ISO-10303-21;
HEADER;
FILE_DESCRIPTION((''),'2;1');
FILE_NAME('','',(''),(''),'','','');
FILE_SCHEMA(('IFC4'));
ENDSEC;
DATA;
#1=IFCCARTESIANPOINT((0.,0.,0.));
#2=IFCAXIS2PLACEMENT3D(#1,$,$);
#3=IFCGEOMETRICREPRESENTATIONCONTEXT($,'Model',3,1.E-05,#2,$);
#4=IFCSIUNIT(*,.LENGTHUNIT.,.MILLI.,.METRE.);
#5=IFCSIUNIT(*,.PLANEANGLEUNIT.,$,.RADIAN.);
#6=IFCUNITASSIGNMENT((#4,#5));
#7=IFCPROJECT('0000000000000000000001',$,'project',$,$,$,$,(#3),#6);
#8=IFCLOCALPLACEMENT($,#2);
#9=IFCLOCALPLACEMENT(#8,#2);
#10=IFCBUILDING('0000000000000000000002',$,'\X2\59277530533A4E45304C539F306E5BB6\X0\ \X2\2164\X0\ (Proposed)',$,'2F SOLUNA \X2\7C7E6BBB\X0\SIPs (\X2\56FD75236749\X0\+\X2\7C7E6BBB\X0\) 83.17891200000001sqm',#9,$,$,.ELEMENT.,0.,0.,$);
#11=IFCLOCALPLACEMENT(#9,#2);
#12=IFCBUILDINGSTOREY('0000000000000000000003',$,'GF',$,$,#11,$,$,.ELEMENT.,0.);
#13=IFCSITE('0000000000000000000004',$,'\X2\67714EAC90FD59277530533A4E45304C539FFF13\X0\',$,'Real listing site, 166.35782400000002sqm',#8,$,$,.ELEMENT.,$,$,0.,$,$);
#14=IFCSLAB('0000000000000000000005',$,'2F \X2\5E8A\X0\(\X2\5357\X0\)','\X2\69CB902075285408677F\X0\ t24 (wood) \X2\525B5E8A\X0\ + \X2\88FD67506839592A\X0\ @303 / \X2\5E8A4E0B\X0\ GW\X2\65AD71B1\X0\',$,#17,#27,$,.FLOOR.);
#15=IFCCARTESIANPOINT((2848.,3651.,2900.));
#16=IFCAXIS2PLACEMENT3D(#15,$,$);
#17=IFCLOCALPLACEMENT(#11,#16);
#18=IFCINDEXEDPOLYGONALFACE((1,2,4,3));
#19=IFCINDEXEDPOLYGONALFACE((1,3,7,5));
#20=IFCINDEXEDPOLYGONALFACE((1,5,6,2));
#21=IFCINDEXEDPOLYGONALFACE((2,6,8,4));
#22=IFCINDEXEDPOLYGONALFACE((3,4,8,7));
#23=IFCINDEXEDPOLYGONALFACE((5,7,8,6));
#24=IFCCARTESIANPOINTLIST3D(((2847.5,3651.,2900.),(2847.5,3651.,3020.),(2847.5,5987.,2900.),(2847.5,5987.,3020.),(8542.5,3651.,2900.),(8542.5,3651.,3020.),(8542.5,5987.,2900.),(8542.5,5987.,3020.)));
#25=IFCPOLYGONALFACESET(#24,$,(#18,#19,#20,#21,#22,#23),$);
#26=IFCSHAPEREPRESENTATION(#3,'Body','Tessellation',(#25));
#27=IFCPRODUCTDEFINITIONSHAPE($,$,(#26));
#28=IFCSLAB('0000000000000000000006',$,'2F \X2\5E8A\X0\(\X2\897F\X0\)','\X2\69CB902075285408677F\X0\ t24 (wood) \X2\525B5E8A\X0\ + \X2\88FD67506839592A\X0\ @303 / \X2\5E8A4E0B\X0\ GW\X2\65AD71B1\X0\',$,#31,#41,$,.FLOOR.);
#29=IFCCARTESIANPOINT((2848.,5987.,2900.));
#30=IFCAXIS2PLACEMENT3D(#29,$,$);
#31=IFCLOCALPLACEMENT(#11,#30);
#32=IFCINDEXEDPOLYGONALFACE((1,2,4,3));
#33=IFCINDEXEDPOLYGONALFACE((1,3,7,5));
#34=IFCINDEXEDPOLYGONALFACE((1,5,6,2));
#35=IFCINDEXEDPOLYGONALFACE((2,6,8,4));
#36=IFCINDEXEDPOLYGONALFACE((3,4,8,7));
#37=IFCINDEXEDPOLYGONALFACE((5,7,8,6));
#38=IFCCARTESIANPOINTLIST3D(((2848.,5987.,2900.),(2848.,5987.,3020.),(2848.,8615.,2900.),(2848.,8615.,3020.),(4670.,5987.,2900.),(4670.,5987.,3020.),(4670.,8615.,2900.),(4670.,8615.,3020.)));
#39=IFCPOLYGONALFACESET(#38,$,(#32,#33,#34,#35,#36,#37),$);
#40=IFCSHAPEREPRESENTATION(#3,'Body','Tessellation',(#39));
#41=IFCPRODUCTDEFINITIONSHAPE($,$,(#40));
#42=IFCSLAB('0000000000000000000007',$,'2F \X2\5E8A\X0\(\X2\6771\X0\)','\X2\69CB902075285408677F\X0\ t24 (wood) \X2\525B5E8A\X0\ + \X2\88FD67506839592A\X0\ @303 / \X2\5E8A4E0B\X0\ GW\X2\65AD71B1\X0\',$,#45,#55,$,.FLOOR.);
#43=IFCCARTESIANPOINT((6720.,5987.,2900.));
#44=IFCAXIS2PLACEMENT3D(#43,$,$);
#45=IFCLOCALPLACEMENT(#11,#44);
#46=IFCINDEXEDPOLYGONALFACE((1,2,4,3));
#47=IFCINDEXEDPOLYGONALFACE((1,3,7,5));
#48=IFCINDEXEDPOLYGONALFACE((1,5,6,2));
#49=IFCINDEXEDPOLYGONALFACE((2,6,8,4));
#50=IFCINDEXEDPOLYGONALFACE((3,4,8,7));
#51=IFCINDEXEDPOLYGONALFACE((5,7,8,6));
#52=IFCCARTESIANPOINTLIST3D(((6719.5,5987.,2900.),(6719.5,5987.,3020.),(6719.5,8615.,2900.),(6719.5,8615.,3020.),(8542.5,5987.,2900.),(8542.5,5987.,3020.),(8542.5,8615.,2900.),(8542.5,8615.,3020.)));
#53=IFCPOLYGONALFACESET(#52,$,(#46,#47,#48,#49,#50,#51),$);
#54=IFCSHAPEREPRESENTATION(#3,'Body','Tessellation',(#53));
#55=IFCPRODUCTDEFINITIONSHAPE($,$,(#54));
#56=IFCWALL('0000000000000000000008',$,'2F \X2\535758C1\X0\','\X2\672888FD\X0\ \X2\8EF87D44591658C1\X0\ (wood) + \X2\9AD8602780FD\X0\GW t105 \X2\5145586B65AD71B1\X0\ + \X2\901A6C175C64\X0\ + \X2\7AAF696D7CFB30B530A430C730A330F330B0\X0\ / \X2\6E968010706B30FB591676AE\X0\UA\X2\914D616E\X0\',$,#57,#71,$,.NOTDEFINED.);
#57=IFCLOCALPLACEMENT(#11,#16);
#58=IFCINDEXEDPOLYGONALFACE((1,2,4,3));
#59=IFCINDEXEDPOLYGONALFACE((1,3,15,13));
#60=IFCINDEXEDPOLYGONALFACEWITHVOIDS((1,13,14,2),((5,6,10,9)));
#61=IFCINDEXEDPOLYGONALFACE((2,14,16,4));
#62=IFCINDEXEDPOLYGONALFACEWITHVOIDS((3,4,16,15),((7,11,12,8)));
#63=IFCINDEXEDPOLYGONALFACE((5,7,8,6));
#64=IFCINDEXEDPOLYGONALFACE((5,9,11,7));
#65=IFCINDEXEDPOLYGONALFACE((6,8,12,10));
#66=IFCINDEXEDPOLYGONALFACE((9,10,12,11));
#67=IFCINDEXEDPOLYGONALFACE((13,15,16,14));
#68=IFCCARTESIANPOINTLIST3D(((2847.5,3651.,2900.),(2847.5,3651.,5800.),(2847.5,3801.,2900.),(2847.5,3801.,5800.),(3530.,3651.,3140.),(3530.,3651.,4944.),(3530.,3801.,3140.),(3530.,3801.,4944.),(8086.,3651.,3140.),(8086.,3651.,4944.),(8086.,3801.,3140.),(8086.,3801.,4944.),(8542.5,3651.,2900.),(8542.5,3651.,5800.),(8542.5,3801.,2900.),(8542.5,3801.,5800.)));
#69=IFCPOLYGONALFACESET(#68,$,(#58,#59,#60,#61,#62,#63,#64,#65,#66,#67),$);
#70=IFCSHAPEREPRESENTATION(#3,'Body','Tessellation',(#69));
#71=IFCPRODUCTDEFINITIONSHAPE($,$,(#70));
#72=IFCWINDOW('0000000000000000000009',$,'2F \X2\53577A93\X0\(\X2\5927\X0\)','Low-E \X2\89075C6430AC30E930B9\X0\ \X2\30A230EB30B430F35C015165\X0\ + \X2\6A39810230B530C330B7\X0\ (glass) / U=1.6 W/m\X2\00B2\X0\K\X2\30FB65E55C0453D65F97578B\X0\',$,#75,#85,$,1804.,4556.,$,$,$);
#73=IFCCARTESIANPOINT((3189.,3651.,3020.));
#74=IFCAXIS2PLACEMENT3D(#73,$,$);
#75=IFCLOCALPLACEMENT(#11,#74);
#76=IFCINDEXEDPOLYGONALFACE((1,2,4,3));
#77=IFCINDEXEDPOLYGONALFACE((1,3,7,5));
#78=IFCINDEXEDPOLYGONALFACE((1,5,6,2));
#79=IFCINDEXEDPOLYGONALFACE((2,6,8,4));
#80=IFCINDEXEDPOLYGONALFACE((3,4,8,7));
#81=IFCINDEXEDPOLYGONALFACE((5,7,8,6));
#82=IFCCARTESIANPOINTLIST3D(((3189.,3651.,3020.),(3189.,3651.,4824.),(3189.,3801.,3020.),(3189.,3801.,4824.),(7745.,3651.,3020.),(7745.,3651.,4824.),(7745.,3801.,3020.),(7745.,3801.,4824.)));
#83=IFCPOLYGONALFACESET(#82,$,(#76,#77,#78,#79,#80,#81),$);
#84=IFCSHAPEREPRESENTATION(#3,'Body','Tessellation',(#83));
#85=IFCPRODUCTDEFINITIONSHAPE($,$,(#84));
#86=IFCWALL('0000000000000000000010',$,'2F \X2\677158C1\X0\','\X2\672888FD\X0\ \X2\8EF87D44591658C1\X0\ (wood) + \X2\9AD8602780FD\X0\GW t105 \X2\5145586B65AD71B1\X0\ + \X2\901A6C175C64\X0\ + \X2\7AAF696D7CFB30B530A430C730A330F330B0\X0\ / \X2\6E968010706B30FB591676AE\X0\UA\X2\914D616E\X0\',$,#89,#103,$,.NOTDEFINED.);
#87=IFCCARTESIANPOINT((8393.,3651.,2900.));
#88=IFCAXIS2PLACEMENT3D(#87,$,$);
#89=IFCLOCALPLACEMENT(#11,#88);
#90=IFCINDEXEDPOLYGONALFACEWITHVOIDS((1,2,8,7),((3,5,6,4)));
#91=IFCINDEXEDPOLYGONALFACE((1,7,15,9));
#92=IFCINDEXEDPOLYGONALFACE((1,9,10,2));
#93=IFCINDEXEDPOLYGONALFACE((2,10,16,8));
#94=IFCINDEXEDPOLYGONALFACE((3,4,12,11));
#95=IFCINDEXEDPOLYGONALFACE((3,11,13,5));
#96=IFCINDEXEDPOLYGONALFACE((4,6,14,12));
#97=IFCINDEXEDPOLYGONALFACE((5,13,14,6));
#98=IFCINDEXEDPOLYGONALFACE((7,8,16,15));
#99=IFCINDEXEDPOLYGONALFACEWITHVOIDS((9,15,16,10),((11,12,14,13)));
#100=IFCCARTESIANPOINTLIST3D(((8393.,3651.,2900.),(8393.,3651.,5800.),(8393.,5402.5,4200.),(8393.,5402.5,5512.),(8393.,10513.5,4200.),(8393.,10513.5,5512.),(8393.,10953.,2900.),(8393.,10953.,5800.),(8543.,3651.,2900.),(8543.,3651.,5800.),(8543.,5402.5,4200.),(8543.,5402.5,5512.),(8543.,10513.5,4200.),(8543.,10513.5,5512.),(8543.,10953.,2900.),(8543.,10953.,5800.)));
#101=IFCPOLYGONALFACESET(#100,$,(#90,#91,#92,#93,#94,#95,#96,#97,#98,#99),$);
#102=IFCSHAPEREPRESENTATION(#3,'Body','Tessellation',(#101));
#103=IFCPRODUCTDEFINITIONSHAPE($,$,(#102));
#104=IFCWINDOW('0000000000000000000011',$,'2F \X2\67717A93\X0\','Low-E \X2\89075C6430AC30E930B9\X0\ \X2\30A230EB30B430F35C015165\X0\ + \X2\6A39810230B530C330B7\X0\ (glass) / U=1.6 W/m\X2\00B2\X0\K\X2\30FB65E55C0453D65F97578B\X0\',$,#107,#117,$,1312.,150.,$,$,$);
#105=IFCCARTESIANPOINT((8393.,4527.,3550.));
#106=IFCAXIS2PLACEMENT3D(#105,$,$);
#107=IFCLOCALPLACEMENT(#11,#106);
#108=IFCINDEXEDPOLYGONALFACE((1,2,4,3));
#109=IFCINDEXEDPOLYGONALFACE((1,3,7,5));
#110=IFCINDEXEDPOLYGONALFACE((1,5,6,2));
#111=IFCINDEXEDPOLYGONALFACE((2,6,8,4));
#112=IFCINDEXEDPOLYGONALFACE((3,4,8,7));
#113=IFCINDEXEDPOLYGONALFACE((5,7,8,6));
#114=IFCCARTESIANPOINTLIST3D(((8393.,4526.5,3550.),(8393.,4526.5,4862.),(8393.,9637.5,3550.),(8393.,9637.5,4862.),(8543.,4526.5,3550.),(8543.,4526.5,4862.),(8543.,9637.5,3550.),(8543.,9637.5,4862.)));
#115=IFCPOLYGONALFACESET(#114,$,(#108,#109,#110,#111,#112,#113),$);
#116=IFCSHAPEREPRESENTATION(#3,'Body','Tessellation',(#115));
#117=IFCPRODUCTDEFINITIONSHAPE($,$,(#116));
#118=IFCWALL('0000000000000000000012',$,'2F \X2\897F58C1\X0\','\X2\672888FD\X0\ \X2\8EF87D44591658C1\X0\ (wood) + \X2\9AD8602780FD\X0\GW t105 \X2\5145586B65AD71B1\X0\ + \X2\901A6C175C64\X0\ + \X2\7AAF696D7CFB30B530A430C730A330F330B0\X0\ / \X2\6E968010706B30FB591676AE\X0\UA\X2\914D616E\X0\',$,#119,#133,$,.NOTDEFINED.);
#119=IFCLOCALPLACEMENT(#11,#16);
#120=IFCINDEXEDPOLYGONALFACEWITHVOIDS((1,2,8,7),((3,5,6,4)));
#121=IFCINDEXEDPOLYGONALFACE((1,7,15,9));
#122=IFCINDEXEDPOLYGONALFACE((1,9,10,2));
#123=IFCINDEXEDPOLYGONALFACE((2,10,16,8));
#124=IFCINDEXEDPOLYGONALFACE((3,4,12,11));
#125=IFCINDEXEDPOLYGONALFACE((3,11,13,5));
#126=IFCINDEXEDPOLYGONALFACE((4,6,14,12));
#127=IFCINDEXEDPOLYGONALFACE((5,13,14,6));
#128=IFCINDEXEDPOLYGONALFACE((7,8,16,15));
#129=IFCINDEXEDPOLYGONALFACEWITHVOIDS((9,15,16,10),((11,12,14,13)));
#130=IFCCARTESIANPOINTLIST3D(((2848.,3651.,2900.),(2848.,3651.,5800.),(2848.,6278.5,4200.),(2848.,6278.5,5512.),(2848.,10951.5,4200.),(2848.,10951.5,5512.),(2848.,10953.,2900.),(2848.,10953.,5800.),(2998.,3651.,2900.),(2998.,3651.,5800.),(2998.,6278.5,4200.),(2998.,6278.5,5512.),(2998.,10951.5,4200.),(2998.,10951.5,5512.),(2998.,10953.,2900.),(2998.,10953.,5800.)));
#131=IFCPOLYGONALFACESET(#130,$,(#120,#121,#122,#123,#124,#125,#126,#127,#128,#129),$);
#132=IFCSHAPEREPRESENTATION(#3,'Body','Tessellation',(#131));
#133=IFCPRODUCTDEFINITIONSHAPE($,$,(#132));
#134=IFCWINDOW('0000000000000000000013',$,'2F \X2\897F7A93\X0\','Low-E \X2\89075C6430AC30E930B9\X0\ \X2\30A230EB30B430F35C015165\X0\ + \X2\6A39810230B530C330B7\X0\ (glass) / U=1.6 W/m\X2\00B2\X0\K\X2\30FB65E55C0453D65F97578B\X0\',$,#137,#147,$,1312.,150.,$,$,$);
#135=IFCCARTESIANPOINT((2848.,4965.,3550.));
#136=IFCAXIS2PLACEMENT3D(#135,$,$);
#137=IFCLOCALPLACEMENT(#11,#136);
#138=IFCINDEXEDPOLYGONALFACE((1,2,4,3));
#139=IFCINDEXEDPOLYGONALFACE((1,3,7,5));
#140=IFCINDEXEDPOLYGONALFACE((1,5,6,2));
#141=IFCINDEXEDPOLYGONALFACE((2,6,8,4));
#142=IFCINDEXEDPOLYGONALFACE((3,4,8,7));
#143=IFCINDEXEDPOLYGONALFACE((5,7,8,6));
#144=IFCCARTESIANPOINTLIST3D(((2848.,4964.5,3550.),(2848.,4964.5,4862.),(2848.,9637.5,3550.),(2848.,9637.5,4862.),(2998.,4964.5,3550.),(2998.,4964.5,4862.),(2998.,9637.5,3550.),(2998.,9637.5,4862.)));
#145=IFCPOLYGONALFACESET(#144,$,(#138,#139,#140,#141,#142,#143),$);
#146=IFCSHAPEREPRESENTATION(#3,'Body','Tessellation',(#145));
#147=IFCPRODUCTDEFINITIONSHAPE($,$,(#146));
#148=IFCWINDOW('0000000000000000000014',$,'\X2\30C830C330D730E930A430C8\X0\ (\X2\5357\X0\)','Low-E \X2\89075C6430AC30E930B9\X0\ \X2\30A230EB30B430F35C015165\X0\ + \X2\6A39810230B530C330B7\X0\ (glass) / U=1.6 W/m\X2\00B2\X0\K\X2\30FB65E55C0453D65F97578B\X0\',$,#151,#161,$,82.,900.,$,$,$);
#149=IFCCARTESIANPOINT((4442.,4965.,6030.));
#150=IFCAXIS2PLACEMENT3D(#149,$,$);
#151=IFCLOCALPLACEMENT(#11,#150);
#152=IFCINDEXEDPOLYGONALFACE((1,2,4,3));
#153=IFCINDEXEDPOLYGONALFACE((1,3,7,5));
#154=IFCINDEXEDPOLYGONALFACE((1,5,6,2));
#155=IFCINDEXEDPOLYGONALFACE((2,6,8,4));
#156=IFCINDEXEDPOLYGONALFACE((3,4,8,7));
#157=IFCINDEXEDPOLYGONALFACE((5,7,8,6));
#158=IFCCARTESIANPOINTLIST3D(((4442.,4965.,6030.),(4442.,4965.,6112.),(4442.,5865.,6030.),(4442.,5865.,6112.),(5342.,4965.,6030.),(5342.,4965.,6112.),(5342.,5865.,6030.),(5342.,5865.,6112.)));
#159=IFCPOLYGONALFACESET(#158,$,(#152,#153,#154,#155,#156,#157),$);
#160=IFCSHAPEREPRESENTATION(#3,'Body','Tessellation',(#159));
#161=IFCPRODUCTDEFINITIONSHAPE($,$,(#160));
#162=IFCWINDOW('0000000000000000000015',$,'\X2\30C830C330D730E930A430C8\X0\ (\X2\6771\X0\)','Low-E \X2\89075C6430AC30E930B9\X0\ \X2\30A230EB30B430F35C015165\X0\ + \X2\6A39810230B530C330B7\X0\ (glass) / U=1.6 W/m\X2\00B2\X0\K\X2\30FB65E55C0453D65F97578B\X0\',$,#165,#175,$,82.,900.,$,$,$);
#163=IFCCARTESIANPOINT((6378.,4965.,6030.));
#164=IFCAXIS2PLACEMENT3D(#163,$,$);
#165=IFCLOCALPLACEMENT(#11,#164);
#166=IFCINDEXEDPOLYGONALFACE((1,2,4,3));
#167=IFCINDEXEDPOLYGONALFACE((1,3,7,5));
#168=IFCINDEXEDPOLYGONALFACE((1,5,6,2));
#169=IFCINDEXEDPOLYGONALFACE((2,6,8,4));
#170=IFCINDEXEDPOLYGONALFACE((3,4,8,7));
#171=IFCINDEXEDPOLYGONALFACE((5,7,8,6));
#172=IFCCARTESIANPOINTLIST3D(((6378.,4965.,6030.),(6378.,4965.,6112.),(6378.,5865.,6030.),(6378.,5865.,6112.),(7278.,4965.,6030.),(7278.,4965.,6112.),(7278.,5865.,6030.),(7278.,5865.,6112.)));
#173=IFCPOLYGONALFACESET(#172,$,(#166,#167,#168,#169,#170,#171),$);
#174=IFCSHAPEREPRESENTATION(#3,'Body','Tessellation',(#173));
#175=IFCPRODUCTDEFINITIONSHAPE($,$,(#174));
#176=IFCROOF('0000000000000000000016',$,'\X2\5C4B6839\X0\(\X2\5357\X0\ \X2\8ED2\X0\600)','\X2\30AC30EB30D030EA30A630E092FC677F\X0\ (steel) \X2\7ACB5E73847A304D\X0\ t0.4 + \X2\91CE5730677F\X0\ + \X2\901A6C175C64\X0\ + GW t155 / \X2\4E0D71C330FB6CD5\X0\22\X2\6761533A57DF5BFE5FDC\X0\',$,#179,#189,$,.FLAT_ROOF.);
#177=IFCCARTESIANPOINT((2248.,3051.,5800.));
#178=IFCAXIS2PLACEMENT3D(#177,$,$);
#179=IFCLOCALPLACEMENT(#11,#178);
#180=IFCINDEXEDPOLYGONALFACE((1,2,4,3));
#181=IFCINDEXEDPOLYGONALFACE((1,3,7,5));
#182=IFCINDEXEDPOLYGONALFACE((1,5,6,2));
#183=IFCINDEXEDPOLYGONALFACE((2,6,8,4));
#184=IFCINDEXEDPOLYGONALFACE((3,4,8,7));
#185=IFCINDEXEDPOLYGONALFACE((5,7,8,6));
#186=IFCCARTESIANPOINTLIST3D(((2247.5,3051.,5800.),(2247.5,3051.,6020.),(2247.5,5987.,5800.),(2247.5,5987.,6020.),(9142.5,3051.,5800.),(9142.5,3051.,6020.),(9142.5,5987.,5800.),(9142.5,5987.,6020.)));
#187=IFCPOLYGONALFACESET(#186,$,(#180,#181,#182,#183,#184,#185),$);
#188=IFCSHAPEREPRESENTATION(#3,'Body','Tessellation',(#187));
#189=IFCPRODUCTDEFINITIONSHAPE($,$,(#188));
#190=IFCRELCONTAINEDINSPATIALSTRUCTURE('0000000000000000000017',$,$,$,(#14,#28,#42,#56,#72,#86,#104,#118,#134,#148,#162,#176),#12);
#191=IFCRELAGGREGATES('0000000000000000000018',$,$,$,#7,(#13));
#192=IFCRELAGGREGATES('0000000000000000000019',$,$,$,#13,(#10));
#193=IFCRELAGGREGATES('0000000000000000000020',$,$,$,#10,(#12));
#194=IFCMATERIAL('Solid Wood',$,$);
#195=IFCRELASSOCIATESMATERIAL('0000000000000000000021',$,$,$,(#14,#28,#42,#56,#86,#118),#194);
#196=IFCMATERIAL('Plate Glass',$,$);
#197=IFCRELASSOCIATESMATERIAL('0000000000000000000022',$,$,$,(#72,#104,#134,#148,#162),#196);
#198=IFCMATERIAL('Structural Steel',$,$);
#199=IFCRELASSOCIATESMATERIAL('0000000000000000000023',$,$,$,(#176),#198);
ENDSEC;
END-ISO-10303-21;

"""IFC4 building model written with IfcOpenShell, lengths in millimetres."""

from ifc_helpers import new_model, si_unit, frame, frame_2d, origin, place, context, project, spatial, rectangle, extrude, material, element, fill, save


model = new_model("IFC4")

# Units and contexts
model_context = context("Model", 3, precision=1e-05, world=origin())
ifc_project = project(units=[si_unit("LENGTHUNIT", "METRE", prefix="MILLI"), si_unit("PLANEANGLEUNIT", "RADIAN")], contexts=[model_context])

# Site, building, storey
site_placement = place(None, origin())
site = spatial("IfcSite", under=ifc_project, at=site_placement, Name="東京都大田区久が原３", ObjectType="Real listing site, 166.35782400000002sqm", CompositionType="ELEMENT", RefElevation=0.0)
building_placement = place(site_placement, origin())
building = spatial("IfcBuilding", under=site, at=building_placement, Name="大田区久が原の家 Ⅴ (Proposed)", ObjectType="2F SOLUNA 籾殻SIPs (国産杉+籾殻) 83.17891200000001sqm", CompositionType="ELEMENT", ElevationOfRefHeight=0.0, ElevationOfTerrain=0.0)
storey_placement = place(building_placement, origin())
storey = spatial("IfcBuildingStorey", under=building, at=storey_placement, Name="GF", CompositionType="ELEMENT", Elevation=0.0)

# Slabs
ifc_material_1 = material(Name="Solid Wood")
slab_1_placement = place(storey_placement, frame((2848.0, 3651.0, 2900.0)))
element("IfcSlab", 1, at=slab_1_placement, inside=storey, material=ifc_material_1, Name="2F 床(南)", Description="構造用合板 t24 (wood) 剛床 + 製材根太 @303 / 床下 GW断熱", PredefinedType="FLOOR", context=model_context, shape_type="SweptSolid", body=[
    extrude(rectangle(XDim=5695.0, YDim=2336.0, at=frame_2d((2847.0, 1168.0))), frame((2848.0, 3651.0, 2900.0)), (0.0, 0.0, 1.0), 120.0),
])
slab_2_placement = place(storey_placement, frame((2848.0, 5987.0, 2900.0)))
element("IfcSlab", 2, at=slab_2_placement, inside=storey, material=ifc_material_1, Name="2F 床(西)", Description="構造用合板 t24 (wood) 剛床 + 製材根太 @303 / 床下 GW断熱", PredefinedType="FLOOR", context=model_context, shape_type="SweptSolid", body=[
    extrude(rectangle(XDim=1822.0, YDim=2628.0, at=frame_2d((911.0, 1314.0))), frame((2848.0, 5987.0, 2900.0)), (0.0, 0.0, 1.0), 120.0),
])
slab_3_placement = place(storey_placement, frame((6720.0, 5987.0, 2900.0)))
element("IfcSlab", 3, at=slab_3_placement, inside=storey, material=ifc_material_1, Name="2F 床(東)", Description="構造用合板 t24 (wood) 剛床 + 製材根太 @303 / 床下 GW断熱", PredefinedType="FLOOR", context=model_context, shape_type="SweptSolid", body=[
    extrude(rectangle(XDim=1823.0, YDim=2628.0, at=frame_2d((911.0, 1314.0))), frame((6720.0, 5987.0, 2900.0)), (0.0, 0.0, 1.0), 120.0),
])

# Walls, openings, windows
wall_1_placement = place(storey_placement, frame((2848.0, 3651.0, 2900.0)))
wall_1 = element("IfcWall", 4, at=wall_1_placement, inside=storey, material=ifc_material_1, Name="2F 南壁", Description="木製 軸組外壁 (wood) + 高性能GW t105 充填断熱 + 通気層 + 窯業系サイディング / 準耐火・外皮UA配慮", PredefinedType="NOTDEFINED", context=model_context, shape_type="SweptSolid", body=[
    extrude(rectangle(XDim=5695.0, YDim=150.0, at=frame_2d((2847.0, 75.0))), frame((2848.0, 3651.0, 2900.0)), (0.0, 0.0, 1.0), 2900.0),
])
opening_1_placement = place(storey_placement, frame((3189.0, 3651.0, 3020.0)))
opening_1 = element("IfcOpeningElement", 5, at=opening_1_placement, cuts=wall_1, PredefinedType="NOTDEFINED", context=model_context, shape_type="SweptSolid", body=[
    extrude(rectangle(XDim=4556.0, YDim=150.0, at=frame_2d((2278.0, 75.0))), frame((3189.0, 3651.0, 3020.0)), (0.0, 0.0, 1.0), 1804.0),
])
ifc_material_2 = material(Name="Plate Glass")
window_1_placement = place(storey_placement, frame((3189.0, 3651.0, 3020.0)))
window_1 = element("IfcWindow", 6, at=window_1_placement, inside=storey, material=ifc_material_2, Name="2F 南窓(大)", Description="Low-E 複層ガラス アルゴン封入 + 樹脂サッシ (glass) / U=1.6 W/m²K・日射取得型", OverallHeight=1804.0, OverallWidth=4556.0, context=model_context, shape_type="SweptSolid", body=[
    extrude(rectangle(XDim=4556.0, YDim=150.0, at=frame_2d((2278.0, 75.0))), frame((3189.0, 3651.0, 3020.0)), (0.0, 0.0, 1.0), 1804.0),
])
fill(opening_1, window_1)
wall_2_placement = place(storey_placement, frame((8393.0, 3651.0, 2900.0)))
wall_2 = element("IfcWall", 7, at=wall_2_placement, inside=storey, material=ifc_material_1, Name="2F 東壁", Description="木製 軸組外壁 (wood) + 高性能GW t105 充填断熱 + 通気層 + 窯業系サイディング / 準耐火・外皮UA配慮", PredefinedType="NOTDEFINED", context=model_context, shape_type="SweptSolid", body=[
    extrude(rectangle(XDim=150.0, YDim=7302.0, at=frame_2d((75.0, 3651.0))), frame((8393.0, 3651.0, 2900.0)), (0.0, 0.0, 1.0), 2900.0),
])
opening_2_placement = place(storey_placement, frame((8393.0, 4527.0, 3550.0)))
opening_2 = element("IfcOpeningElement", 8, at=opening_2_placement, cuts=wall_2, PredefinedType="NOTDEFINED", context=model_context, shape_type="SweptSolid", body=[
    extrude(rectangle(XDim=150.0, YDim=5111.0, at=frame_2d((75.0, 2555.0))), frame((8393.0, 4527.0, 3550.0)), (0.0, 0.0, 1.0), 1312.0),
])
window_2_placement = place(storey_placement, frame((8393.0, 4527.0, 3550.0)))
window_2 = element("IfcWindow", 9, at=window_2_placement, inside=storey, material=ifc_material_2, Name="2F 東窓", Description="Low-E 複層ガラス アルゴン封入 + 樹脂サッシ (glass) / U=1.6 W/m²K・日射取得型", OverallHeight=1312.0, OverallWidth=150.0, context=model_context, shape_type="SweptSolid", body=[
    extrude(rectangle(XDim=150.0, YDim=5111.0, at=frame_2d((75.0, 2555.0))), frame((8393.0, 4527.0, 3550.0)), (0.0, 0.0, 1.0), 1312.0),
])
fill(opening_2, window_2)
wall_3_placement = place(storey_placement, frame((2848.0, 3651.0, 2900.0)))
wall_3 = element("IfcWall", 10, at=wall_3_placement, inside=storey, material=ifc_material_1, Name="2F 西壁", Description="木製 軸組外壁 (wood) + 高性能GW t105 充填断熱 + 通気層 + 窯業系サイディング / 準耐火・外皮UA配慮", PredefinedType="NOTDEFINED", context=model_context, shape_type="SweptSolid", body=[
    extrude(rectangle(XDim=150.0, YDim=7302.0, at=frame_2d((75.0, 3651.0))), frame((2848.0, 3651.0, 2900.0)), (0.0, 0.0, 1.0), 2900.0),
])
opening_3_placement = place(storey_placement, frame((2848.0, 4965.0, 3550.0)))
opening_3 = element("IfcOpeningElement", 11, at=opening_3_placement, cuts=wall_3, PredefinedType="NOTDEFINED", context=model_context, shape_type="SweptSolid", body=[
    extrude(rectangle(XDim=150.0, YDim=4673.0, at=frame_2d((75.0, 2336.0))), frame((2848.0, 4965.0, 3550.0)), (0.0, 0.0, 1.0), 1312.0),
])
window_3_placement = place(storey_placement, frame((2848.0, 4965.0, 3550.0)))
window_3 = element("IfcWindow", 12, at=window_3_placement, inside=storey, material=ifc_material_2, Name="2F 西窓", Description="Low-E 複層ガラス アルゴン封入 + 樹脂サッシ (glass) / U=1.6 W/m²K・日射取得型", OverallHeight=1312.0, OverallWidth=150.0, context=model_context, shape_type="SweptSolid", body=[
    extrude(rectangle(XDim=150.0, YDim=4673.0, at=frame_2d((75.0, 2336.0))), frame((2848.0, 4965.0, 3550.0)), (0.0, 0.0, 1.0), 1312.0),
])
fill(opening_3, window_3)

# Windows
window_4_placement = place(storey_placement, frame((4442.0, 4965.0, 6030.0)))
element("IfcWindow", 13, at=window_4_placement, inside=storey, material=ifc_material_2, Name="トップライト (南)", Description="Low-E 複層ガラス アルゴン封入 + 樹脂サッシ (glass) / U=1.6 W/m²K・日射取得型", OverallHeight=82.0, OverallWidth=900.0, context=model_context, shape_type="SweptSolid", body=[
    extrude(rectangle(XDim=900.0, YDim=900.0, at=frame_2d((450.0, 450.0))), frame((4442.0, 4965.0, 6030.0)), (0.0, 0.0, 1.0), 82.0),
])
window_5_placement = place(storey_placement, frame((6378.0, 4965.0, 6030.0)))
element("IfcWindow", 14, at=window_5_placement, inside=storey, material=ifc_material_2, Name="トップライト (東)", Description="Low-E 複層ガラス アルゴン封入 + 樹脂サッシ (glass) / U=1.6 W/m²K・日射取得型", OverallHeight=82.0, OverallWidth=900.0, context=model_context, shape_type="SweptSolid", body=[
    extrude(rectangle(XDim=900.0, YDim=900.0, at=frame_2d((450.0, 450.0))), frame((6378.0, 4965.0, 6030.0)), (0.0, 0.0, 1.0), 82.0),
])

# Roof
ifc_material_3 = material(Name="Structural Steel")
roof_1_placement = place(storey_placement, frame((2248.0, 3051.0, 5800.0)))
element("IfcRoof", 15, at=roof_1_placement, inside=storey, material=ifc_material_3, Name="屋根(南 軒600)", Description="ガルバリウム鋼板 (steel) 立平葺き t0.4 + 野地板 + 通気層 + GW t155 / 不燃・法22条区域対応", PredefinedType="FLAT_ROOF", context=model_context, shape_type="SweptSolid", body=[
    extrude(rectangle(XDim=6895.0, YDim=2936.0, at=frame_2d((3447.0, 1468.0))), frame((2248.0, 3051.0, 5800.0)), (0.0, 0.0, 1.0), 220.0),
])

save(model, "model.ifc")
